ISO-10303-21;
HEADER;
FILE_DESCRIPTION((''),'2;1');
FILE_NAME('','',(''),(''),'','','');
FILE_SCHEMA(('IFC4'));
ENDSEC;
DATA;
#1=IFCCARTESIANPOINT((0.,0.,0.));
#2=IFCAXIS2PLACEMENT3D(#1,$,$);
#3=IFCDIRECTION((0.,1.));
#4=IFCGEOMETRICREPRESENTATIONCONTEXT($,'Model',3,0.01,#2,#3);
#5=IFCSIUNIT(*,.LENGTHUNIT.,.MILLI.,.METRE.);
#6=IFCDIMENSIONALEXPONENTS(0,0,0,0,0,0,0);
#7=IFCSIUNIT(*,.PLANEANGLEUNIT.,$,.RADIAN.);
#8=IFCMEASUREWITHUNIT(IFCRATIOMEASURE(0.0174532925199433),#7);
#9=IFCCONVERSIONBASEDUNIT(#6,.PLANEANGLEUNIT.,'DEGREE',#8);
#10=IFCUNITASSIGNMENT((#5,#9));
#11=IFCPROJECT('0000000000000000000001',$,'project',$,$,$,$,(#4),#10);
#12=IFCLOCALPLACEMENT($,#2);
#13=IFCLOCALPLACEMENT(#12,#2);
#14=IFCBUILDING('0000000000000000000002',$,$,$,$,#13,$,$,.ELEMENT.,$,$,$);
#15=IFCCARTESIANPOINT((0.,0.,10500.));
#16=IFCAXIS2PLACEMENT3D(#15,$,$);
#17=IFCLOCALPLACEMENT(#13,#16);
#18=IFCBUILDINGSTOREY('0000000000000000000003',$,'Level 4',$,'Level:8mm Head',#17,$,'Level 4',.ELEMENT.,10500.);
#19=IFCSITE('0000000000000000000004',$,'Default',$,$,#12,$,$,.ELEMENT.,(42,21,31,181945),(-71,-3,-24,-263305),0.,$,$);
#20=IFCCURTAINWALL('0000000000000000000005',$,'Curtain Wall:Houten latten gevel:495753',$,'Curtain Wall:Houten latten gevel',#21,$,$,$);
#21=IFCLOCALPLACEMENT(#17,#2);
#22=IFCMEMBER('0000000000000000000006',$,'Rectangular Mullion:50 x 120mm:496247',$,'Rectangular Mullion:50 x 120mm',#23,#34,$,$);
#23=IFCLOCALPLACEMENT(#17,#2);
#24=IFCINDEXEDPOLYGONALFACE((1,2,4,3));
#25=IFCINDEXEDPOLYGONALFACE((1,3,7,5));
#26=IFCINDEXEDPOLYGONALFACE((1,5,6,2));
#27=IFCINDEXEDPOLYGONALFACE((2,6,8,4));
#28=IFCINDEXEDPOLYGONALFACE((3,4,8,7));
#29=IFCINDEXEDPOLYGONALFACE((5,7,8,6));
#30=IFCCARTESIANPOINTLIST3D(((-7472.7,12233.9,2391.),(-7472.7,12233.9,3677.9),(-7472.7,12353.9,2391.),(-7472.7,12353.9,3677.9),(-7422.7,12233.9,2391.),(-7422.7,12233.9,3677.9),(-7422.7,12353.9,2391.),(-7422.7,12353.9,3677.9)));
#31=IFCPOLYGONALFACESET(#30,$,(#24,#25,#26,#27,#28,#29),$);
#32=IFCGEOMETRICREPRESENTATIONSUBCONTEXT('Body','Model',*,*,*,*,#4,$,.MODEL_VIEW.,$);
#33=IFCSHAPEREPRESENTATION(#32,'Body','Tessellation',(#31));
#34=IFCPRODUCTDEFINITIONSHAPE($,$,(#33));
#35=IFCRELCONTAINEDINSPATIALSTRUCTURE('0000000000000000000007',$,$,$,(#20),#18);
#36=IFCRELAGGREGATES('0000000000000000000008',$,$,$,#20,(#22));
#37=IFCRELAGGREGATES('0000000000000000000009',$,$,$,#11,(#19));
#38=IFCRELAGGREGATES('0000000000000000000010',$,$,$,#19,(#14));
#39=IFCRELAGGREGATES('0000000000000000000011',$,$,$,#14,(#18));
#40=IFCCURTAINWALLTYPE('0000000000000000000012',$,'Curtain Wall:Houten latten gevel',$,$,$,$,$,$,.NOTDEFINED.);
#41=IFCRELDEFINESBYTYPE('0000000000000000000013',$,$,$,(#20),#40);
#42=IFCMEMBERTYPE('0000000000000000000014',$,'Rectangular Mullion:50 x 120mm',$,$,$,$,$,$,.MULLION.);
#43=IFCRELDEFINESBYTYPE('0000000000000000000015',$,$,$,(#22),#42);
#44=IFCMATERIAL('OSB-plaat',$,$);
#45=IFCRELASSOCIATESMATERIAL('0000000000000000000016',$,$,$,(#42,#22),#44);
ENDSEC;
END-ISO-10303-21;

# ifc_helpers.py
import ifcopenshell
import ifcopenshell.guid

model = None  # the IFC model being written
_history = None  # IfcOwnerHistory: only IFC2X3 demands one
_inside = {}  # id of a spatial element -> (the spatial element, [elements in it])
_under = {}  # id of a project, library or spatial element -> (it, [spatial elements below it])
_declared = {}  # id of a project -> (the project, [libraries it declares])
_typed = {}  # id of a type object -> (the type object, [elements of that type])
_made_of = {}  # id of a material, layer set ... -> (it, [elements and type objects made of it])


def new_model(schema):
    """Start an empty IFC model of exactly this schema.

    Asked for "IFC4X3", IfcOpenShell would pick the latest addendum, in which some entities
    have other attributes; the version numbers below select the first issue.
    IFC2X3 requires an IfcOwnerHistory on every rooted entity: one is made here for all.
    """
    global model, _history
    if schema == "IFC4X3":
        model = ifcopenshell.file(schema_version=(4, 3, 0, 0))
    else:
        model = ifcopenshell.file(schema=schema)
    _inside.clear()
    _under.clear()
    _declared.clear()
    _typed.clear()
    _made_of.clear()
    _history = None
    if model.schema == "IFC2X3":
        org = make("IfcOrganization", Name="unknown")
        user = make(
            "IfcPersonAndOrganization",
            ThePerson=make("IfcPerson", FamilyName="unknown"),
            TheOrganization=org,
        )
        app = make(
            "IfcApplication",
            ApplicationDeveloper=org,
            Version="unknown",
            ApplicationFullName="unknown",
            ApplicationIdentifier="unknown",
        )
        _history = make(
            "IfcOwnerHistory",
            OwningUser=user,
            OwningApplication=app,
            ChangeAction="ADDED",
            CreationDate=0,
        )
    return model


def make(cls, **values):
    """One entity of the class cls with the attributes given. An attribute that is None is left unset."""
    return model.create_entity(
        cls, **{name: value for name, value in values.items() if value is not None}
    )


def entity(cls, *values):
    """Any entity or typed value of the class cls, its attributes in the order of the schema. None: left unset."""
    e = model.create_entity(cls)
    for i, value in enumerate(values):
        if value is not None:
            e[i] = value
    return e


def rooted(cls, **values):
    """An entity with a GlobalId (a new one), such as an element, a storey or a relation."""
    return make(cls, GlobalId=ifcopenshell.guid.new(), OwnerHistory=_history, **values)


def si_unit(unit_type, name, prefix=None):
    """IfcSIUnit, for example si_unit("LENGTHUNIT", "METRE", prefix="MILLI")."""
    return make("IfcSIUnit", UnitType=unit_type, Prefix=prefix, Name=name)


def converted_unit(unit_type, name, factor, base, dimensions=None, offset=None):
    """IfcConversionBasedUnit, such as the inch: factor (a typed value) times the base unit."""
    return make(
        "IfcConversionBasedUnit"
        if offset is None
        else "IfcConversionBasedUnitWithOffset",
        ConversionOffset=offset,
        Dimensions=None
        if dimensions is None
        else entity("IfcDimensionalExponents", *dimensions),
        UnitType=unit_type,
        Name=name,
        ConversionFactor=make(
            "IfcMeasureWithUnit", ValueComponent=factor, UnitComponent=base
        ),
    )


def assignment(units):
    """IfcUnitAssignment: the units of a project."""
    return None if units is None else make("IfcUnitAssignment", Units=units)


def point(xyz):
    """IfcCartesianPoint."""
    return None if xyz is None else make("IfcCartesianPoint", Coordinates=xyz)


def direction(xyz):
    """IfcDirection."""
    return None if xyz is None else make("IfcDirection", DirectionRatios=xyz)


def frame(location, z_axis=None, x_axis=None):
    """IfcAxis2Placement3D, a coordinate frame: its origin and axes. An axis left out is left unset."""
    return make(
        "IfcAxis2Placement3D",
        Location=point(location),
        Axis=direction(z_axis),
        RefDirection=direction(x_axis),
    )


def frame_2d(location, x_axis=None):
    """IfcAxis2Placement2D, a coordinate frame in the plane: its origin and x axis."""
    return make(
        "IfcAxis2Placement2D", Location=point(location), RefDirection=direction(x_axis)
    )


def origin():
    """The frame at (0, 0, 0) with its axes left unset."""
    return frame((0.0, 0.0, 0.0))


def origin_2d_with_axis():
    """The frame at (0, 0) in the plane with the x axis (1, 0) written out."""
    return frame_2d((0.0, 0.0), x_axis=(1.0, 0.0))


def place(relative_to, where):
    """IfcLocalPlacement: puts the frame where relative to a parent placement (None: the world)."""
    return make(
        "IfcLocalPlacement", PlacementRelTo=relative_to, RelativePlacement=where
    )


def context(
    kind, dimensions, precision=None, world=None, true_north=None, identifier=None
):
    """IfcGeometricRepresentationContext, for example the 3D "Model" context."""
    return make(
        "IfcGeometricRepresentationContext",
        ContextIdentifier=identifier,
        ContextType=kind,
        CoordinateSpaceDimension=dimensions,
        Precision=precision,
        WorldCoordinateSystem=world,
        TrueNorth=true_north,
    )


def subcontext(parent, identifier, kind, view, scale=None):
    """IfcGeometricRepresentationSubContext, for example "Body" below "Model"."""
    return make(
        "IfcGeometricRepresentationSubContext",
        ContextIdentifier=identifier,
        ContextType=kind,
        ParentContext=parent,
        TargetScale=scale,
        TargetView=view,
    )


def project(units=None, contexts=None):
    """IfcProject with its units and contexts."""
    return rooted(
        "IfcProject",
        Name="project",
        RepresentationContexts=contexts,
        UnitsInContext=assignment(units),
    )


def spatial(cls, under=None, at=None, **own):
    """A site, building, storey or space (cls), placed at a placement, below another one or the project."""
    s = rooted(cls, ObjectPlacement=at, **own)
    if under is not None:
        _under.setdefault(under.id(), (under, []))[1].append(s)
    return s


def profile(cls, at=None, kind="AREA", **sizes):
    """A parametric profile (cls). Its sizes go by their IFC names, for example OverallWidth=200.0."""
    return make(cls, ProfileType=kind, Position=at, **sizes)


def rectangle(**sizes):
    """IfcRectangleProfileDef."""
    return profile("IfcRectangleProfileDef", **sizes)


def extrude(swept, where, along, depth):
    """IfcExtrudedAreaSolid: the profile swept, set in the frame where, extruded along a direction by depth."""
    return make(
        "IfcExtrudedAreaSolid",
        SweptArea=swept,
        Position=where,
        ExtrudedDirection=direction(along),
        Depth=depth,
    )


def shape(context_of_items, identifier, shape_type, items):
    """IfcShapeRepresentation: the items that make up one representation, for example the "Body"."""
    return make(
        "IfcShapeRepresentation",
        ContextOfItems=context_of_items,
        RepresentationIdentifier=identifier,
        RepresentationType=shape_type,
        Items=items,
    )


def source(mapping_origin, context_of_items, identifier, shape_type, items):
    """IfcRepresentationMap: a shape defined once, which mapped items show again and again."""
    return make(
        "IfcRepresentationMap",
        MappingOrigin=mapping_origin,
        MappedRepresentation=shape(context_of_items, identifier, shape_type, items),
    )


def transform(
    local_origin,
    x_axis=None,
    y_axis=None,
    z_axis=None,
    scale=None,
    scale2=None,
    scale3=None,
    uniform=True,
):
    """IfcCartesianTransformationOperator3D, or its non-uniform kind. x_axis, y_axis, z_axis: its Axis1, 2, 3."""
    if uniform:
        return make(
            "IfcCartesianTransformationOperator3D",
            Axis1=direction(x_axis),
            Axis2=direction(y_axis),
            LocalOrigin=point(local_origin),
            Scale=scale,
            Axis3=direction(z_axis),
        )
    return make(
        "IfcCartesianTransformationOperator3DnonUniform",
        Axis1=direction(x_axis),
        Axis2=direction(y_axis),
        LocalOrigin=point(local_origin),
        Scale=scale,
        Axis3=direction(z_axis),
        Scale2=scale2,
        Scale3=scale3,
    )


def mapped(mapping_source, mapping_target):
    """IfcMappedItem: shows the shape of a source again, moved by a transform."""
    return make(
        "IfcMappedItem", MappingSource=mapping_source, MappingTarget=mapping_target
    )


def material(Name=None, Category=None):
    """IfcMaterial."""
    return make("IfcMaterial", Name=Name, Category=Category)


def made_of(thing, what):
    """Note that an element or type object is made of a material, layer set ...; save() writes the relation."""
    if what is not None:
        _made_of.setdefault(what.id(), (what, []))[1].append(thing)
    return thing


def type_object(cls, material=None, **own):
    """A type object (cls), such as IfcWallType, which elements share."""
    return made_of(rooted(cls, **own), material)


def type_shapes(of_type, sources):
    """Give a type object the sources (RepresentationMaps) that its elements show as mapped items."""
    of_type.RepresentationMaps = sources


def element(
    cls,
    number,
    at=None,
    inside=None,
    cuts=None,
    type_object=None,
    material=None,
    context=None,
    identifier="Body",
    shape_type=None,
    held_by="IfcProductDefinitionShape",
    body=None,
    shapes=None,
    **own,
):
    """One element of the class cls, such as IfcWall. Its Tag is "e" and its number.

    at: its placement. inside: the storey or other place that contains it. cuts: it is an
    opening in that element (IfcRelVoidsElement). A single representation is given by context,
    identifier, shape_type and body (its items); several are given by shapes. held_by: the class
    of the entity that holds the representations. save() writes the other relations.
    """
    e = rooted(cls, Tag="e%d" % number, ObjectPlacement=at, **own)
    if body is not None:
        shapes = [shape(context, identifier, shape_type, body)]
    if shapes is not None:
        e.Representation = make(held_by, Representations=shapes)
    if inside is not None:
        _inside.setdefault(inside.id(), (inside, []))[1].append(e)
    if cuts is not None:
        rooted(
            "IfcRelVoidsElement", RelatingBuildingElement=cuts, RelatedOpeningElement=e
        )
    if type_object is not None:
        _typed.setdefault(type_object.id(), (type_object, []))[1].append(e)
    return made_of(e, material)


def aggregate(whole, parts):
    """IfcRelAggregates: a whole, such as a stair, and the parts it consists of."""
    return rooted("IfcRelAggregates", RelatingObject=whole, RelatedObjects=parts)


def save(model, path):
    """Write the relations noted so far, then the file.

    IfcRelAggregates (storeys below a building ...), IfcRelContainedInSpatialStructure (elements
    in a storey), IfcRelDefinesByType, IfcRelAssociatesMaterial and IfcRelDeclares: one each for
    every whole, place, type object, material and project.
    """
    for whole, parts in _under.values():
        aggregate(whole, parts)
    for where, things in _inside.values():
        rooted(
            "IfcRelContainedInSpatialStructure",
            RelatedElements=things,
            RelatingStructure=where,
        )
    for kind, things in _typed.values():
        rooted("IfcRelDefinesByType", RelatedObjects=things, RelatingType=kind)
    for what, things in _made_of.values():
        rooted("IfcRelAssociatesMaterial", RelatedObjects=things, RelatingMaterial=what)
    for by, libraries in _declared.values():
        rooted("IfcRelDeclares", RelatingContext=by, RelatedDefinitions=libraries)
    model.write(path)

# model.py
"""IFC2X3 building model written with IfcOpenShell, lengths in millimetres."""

from ifc_helpers import new_model, entity, si_unit, converted_unit, direction, frame, origin, origin_2d_with_axis, place, context, subcontext, project, spatial, rectangle, extrude, source, transform, mapped, material, type_object, type_shapes, element, aggregate, save


model = new_model("IFC2X3")

# Units and contexts
model_context = context("Model", 3, precision=0.01, world=origin(), true_north=direction((0.0, 1.0)))
body_context = subcontext(model_context, "Body", "Model", "MODEL_VIEW")
ifc_project = project(units=[si_unit("LENGTHUNIT", "METRE", prefix="MILLI"), converted_unit("PLANEANGLEUNIT", "DEGREE", entity("IfcRatioMeasure", 0.0174532925199433), si_unit("PLANEANGLEUNIT", "RADIAN"), dimensions=[0, 0, 0, 0, 0, 0, 0])], contexts=[model_context])

# Site, building, storey
site_placement = place(None, frame((0.0, 0.0, 0.0)))
site = spatial("IfcSite", under=ifc_project, at=site_placement, Name="Default", CompositionType="ELEMENT", RefLatitude=(42, 21, 31, 181945), RefLongitude=(-71, -3, -24, -263305), RefElevation=0.0)
building_placement = place(site_placement, origin())
building = spatial("IfcBuilding", under=site, at=building_placement, CompositionType="ELEMENT")
storey_placement = place(building_placement, frame((0.0, 0.0, 10500.0)))
storey = spatial("IfcBuildingStorey", under=building, at=storey_placement, Name="Level 4", ObjectType="Level:8mm Head", LongName="Level 4", CompositionType="ELEMENT", Elevation=10500.0)

# Curtain wall, member
curtain_wall_type = type_object("IfcCurtainWallType", Name="Curtain Wall:Houten latten gevel", PredefinedType="NOTDEFINED")
curtain_wall_placement = place(storey_placement, frame((0.0, 0.0, -10500.0)))
curtain_wall = element("IfcCurtainWall", 1, at=curtain_wall_placement, inside=storey, type_object=curtain_wall_type, Name="Curtain Wall:Houten latten gevel:495753", ObjectType="Curtain Wall:Houten latten gevel")
ifc_material = material(Name="OSB-plaat")
placement = place(building_placement, frame((0.0, 0.0, 7500.0)))
member_type_1 = type_object("IfcMemberType", Name="Rectangular Mullion:50 x 120mm", PredefinedType="MULLION", material=ifc_material)
shared_shape_1 = source(origin(), body_context, "Body", "SweptSolid", [
    extrude(rectangle(XDim=120.0, YDim=50.0, at=origin_2d_with_axis()), frame((0.0, 0.0, -1286.9), z_axis=(0.0, 0.0, 1.0), x_axis=(0.0, -1.0, 0.0)), (0.0, 0.0, 1.0), 1286.9),
])
type_shapes(member_type_1, [shared_shape_1])
member_1_placement = place(placement, frame((-7447.7, 12293.9, 5391.0), z_axis=(0.0, 0.0, -1.0), x_axis=(1.0, 0.0, 0.0)))
member_1 = element("IfcMember", 2, at=member_1_placement, type_object=member_type_1, material=ifc_material, Name="Rectangular Mullion:50 x 120mm:496247", ObjectType="Rectangular Mullion:50 x 120mm", context=body_context, shape_type="MappedRepresentation", body=[
    mapped(shared_shape_1, transform((0.0, 0.0, 0.0), scale=1.0)),
])
aggregate(curtain_wall, [member_1])

save(model, "model.ifc")
